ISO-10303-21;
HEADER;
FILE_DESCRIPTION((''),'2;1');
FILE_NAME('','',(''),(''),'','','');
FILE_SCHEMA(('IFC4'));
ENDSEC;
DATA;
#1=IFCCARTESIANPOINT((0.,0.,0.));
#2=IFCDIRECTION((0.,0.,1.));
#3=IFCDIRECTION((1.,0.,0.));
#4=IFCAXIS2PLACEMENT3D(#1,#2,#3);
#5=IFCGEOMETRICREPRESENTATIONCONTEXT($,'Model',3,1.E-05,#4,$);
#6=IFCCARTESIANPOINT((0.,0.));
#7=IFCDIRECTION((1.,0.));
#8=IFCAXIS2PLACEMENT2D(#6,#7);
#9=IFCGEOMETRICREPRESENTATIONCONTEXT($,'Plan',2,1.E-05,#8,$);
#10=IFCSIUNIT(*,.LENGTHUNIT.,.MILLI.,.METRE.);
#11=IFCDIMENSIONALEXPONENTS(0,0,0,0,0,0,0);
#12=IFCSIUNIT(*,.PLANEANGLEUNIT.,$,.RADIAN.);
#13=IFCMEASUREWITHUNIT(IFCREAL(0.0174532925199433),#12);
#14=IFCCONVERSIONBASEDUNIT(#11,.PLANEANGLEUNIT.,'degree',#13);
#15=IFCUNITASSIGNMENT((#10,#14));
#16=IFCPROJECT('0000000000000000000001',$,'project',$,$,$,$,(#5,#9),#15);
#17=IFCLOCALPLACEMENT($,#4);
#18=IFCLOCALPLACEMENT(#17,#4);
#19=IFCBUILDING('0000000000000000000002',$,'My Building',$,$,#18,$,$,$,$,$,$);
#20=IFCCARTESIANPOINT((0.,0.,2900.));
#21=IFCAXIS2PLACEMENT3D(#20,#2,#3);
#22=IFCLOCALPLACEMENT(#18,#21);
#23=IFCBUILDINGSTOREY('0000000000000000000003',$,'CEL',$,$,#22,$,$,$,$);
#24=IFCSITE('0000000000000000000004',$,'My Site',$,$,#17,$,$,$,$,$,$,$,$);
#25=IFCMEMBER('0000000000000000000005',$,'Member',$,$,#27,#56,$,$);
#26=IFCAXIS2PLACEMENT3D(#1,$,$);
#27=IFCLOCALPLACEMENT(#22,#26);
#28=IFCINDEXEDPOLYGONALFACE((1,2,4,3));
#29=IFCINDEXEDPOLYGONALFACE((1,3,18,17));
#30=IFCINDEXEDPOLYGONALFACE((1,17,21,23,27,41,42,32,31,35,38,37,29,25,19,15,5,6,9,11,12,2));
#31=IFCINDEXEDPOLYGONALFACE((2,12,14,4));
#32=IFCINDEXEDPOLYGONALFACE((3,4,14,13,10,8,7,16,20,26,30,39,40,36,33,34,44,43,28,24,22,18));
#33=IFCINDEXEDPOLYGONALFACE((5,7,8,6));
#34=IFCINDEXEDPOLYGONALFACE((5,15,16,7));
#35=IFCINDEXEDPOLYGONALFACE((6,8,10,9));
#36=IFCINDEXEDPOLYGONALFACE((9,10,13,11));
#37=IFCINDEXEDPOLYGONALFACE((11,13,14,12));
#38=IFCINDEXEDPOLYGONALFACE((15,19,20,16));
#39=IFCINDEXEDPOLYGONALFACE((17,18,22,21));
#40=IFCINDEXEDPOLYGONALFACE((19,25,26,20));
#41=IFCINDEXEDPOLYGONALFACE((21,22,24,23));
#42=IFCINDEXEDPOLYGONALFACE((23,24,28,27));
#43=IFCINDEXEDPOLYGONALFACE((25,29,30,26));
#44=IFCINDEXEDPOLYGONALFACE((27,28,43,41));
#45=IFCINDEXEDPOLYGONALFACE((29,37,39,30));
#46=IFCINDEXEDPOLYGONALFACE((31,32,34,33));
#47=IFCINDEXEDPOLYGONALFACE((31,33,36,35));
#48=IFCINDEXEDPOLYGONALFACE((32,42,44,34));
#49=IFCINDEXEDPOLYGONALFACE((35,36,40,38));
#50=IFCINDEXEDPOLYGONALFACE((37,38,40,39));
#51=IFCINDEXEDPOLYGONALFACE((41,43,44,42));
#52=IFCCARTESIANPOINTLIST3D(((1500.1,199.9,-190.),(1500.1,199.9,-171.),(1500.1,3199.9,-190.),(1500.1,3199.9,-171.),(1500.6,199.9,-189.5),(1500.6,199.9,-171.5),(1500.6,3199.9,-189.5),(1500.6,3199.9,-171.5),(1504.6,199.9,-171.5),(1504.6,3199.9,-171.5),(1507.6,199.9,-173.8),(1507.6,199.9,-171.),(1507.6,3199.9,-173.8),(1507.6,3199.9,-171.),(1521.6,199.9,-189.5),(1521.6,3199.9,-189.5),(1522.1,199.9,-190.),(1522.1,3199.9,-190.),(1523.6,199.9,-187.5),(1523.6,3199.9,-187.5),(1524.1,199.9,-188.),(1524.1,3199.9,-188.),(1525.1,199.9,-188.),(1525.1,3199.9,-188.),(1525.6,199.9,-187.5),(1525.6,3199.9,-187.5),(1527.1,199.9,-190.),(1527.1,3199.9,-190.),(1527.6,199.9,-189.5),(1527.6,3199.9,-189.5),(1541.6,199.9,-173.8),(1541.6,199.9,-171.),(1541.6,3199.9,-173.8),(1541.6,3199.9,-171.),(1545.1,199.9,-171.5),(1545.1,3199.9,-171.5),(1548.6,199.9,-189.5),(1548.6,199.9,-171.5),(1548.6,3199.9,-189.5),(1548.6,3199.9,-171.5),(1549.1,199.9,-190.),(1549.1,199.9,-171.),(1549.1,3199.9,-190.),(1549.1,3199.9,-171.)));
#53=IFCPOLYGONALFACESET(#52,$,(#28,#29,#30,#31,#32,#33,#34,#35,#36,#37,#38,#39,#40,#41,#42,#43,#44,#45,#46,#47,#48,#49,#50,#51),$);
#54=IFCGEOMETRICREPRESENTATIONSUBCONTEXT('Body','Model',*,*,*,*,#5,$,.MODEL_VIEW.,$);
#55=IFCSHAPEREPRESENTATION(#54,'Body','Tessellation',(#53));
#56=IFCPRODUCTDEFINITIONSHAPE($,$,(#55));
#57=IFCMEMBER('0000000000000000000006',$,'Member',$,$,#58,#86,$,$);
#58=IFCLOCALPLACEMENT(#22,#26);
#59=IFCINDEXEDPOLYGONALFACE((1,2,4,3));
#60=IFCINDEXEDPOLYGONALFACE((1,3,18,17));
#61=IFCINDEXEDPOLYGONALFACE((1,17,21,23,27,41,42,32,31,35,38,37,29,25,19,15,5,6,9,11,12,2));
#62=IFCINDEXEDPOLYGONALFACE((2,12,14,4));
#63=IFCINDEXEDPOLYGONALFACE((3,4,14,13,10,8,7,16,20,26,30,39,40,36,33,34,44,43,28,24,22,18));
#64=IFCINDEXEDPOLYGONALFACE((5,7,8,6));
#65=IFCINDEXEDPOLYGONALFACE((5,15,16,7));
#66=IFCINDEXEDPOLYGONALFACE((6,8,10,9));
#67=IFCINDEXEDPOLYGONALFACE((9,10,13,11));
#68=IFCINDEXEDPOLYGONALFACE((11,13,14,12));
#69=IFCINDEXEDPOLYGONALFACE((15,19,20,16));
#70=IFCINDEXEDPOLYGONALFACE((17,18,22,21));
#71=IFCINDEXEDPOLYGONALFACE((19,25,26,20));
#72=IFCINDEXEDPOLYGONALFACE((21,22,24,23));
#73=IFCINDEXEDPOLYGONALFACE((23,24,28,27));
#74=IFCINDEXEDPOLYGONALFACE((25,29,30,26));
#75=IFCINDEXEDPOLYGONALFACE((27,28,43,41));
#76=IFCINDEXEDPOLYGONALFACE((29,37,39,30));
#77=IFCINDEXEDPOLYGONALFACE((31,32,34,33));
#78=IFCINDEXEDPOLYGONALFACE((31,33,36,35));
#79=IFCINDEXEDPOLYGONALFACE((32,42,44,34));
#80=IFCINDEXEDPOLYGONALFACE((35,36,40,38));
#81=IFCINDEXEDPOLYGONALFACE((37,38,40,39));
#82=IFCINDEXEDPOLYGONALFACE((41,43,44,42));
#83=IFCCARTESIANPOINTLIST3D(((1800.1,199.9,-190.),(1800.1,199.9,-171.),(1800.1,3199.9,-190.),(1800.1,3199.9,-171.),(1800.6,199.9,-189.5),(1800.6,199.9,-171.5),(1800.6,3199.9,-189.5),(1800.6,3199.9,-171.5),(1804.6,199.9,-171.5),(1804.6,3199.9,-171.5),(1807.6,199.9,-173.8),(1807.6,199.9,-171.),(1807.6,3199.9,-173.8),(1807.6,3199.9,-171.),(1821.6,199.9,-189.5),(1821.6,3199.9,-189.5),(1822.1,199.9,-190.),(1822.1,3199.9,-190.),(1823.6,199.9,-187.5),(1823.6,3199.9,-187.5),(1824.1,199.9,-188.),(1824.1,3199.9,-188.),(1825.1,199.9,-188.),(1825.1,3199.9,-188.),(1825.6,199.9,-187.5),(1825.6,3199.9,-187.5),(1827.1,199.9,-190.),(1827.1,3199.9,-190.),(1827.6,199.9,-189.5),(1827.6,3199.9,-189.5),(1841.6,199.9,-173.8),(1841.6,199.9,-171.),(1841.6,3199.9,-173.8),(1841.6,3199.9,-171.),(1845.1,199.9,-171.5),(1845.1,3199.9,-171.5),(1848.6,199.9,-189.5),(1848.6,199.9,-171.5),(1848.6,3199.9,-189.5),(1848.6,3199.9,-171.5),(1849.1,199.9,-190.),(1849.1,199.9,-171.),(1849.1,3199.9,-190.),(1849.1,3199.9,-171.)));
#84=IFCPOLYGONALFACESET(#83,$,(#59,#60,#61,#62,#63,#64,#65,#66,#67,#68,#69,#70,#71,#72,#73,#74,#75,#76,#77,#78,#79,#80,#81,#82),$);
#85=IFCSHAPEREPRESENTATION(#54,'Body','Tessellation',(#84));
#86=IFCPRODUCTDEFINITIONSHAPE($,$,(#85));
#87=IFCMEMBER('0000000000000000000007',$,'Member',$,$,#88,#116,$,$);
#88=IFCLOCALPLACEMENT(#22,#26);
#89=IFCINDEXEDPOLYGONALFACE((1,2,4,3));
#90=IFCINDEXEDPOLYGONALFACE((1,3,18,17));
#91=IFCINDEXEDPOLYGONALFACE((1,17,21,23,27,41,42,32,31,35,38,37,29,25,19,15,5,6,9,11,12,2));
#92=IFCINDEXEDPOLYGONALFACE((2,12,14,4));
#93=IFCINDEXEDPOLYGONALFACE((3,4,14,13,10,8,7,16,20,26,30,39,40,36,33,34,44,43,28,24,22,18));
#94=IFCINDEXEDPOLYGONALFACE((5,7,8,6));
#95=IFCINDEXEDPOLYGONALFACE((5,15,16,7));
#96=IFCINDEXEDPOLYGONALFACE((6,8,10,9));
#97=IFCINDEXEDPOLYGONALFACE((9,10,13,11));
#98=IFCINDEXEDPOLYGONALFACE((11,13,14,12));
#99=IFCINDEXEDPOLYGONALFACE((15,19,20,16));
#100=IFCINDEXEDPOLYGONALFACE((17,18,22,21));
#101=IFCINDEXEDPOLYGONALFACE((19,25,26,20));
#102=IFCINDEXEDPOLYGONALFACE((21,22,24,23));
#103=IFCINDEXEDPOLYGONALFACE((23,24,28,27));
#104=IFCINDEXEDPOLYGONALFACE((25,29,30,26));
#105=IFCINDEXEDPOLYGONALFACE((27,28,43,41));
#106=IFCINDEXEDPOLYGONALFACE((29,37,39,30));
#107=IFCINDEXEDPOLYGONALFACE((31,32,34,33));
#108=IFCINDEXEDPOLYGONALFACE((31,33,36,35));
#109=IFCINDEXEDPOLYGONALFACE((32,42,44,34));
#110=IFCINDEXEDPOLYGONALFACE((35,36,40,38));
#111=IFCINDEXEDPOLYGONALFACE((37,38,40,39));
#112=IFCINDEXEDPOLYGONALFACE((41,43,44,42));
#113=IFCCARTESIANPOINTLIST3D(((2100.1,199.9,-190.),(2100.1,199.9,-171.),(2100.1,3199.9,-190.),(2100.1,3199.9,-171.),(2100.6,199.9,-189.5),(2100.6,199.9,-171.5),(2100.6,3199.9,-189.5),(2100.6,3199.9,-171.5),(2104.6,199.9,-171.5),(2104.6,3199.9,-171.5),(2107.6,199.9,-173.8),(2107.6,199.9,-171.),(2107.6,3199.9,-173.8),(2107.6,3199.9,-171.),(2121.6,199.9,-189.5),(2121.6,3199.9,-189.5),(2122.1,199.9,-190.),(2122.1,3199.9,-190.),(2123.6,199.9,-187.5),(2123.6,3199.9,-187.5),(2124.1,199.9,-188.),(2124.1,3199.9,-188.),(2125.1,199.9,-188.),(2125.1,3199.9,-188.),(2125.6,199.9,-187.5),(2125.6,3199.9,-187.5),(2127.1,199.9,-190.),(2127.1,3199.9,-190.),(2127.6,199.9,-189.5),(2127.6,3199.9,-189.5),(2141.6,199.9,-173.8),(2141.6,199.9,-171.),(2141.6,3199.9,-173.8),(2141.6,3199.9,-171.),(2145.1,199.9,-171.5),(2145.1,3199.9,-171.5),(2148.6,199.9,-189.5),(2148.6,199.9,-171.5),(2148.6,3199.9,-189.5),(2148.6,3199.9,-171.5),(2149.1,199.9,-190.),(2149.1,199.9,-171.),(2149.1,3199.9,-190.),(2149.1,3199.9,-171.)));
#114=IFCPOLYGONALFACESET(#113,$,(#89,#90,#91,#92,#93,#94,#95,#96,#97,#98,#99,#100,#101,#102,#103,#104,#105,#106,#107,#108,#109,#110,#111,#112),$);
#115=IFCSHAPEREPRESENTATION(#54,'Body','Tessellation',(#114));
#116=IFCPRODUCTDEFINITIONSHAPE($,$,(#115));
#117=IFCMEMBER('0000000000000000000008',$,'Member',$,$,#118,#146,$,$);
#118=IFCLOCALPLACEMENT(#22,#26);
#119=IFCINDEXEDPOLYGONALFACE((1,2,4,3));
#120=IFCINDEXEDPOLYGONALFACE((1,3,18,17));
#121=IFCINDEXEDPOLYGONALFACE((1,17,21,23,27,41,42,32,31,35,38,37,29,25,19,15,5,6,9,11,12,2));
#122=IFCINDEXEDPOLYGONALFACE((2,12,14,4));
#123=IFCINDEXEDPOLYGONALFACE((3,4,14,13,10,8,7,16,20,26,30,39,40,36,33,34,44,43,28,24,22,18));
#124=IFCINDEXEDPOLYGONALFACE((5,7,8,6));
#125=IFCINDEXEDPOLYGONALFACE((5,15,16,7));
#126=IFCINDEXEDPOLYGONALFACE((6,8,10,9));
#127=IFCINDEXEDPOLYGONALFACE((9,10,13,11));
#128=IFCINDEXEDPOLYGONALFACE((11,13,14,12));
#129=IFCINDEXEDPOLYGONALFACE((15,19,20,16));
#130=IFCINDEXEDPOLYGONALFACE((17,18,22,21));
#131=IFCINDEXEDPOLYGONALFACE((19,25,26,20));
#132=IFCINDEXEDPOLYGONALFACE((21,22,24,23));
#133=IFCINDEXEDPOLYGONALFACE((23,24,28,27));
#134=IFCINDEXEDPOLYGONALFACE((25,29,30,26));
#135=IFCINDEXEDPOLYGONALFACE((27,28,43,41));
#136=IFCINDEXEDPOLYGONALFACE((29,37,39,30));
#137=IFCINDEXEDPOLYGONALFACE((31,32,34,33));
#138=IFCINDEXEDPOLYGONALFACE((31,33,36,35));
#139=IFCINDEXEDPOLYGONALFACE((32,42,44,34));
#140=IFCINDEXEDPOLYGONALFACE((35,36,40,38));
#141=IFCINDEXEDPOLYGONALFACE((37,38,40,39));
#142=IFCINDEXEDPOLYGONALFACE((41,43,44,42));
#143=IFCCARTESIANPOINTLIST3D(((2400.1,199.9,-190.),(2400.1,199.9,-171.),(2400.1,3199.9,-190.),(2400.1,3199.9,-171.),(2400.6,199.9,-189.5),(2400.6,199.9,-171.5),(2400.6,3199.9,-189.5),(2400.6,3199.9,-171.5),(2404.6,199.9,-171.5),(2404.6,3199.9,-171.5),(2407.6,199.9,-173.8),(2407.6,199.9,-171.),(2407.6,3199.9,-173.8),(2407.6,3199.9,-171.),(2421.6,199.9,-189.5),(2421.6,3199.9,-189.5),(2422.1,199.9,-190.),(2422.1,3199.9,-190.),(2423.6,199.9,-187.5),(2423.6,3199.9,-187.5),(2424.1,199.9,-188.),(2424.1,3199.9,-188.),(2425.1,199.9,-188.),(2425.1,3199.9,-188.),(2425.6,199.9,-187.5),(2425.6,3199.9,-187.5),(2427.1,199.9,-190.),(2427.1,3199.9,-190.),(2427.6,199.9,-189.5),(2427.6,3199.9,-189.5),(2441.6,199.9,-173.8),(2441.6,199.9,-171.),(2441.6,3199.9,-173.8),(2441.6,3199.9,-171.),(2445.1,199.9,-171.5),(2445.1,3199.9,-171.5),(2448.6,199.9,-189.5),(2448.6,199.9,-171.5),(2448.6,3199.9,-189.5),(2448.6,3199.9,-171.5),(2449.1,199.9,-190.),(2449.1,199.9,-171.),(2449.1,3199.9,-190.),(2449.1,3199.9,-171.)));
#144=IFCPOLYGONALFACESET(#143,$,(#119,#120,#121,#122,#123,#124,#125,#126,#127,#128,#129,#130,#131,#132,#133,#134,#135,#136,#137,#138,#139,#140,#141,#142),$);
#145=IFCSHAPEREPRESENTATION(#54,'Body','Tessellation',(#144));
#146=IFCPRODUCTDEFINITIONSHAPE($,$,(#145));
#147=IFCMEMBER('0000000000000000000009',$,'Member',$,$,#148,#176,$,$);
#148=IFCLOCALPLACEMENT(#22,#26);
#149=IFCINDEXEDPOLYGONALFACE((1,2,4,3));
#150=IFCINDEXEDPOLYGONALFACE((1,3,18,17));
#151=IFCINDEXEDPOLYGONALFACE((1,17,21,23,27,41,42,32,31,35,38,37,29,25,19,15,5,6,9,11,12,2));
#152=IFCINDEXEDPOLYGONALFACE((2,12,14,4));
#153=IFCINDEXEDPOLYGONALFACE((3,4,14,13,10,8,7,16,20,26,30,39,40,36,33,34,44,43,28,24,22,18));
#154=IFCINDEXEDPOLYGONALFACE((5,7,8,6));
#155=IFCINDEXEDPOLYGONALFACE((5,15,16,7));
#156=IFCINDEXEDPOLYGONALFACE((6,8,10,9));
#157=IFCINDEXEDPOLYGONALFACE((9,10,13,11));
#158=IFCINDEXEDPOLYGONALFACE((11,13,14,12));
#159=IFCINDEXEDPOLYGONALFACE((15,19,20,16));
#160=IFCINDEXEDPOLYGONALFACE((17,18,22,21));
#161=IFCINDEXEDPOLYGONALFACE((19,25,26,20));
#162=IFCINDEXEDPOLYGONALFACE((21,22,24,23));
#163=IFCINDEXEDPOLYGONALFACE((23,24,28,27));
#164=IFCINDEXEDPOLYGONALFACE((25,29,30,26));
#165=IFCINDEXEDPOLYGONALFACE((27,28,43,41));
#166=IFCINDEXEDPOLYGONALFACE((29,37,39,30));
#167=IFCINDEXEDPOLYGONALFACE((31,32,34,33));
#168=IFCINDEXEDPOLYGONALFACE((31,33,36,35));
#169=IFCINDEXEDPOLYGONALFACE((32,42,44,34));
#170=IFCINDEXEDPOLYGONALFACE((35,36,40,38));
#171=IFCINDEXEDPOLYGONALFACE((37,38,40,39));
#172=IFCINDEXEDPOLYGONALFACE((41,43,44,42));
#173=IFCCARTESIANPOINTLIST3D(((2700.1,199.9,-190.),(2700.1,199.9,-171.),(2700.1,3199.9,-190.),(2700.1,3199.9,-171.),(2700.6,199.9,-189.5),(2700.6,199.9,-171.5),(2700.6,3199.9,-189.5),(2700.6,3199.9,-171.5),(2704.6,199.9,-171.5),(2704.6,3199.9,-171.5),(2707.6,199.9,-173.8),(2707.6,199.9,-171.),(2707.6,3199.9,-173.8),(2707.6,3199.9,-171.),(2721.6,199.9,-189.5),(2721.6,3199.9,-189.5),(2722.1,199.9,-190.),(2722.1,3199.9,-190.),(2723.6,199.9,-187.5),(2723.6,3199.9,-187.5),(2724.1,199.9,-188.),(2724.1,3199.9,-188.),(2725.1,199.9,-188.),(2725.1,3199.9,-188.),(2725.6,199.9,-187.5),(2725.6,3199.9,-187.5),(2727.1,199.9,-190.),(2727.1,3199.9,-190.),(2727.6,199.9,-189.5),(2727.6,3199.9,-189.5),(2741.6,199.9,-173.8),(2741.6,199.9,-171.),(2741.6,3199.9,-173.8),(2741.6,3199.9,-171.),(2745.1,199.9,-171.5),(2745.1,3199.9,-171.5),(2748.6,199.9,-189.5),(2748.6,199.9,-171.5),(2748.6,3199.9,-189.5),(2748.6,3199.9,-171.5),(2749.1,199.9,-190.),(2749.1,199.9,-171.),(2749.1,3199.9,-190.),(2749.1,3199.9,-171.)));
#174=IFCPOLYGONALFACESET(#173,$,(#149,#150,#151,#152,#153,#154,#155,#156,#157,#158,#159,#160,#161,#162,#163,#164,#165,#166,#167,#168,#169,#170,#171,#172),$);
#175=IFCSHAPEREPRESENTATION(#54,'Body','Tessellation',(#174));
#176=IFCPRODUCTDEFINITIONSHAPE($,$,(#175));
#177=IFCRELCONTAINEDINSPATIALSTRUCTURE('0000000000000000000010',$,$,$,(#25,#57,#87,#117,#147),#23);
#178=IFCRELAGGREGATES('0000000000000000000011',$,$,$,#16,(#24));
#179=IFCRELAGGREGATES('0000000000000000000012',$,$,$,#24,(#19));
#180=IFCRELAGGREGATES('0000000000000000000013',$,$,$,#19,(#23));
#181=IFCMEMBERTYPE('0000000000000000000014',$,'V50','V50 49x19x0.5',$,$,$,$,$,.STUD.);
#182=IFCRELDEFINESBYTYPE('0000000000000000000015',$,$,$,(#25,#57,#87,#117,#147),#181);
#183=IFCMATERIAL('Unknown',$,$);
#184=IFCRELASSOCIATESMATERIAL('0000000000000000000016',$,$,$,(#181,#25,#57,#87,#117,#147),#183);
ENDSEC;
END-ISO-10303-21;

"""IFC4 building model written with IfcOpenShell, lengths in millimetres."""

from ifc_helpers import new_model, entity, si_unit, converted_unit, frame, origin_with_axes, origin_2d_with_axis, place, context, subcontext, project, spatial, indexed_curve, outline, extrude, material, material_profile, profile_set, profile_usage, type_object, element, save


model = new_model("IFC4")

# Units and contexts
model_context = context("Model", 3, precision=1e-05, world=origin_with_axes())
plan_context = context("Plan", 2, precision=1e-05, world=origin_2d_with_axis())
body_context = subcontext(model_context, "Body", "Model", "MODEL_VIEW")
ifc_project = project(units=[si_unit("LENGTHUNIT", "METRE", prefix="MILLI"), converted_unit("PLANEANGLEUNIT", "degree", entity("IfcReal", 0.0174532925199433), si_unit("PLANEANGLEUNIT", "RADIAN"), dimensions=[0, 0, 0, 0, 0, 0, 0])], contexts=[model_context, plan_context])

# Site, building, storey
site_placement = place(None, origin_with_axes())
site = spatial("IfcSite", under=ifc_project, at=site_placement, Name="My Site")
building_placement = place(site_placement, origin_with_axes())
building = spatial("IfcBuilding", under=site, at=building_placement, Name="My Building")
storey_placement = place(building_placement, frame((0.0, 0.0, 2900.0), z_axis=(0.0, 0.0, 1.0), x_axis=(1.0, 0.0, 0.0)))
storey = spatial("IfcBuildingStorey", under=building, at=storey_placement, Name="CEL")

# Members
ifc_material = material(Name="Unknown")
ifc_material_profile = material_profile(ifc_material, outline(indexed_curve([(-49.0, 0.0), (-49.0, 19.0), (-41.5, 19.0), (-41.5, 16.2), (-45.0, 18.5), (-48.5, 18.5), (-48.5, 0.5), (-27.5, 0.5), (-25.5, 2.5), (-23.5, 2.5), (-21.5, 0.5), (-0.5, 0.5), (-0.5, 18.5), (-4.5, 18.5), (-7.5, 16.2), (-7.5, 19.0), (0.0, 19.0), (0.0, 0.0), (-22.0, 0.0), (-24.0, 2.0), (-25.0, 2.0), (-27.0, 0.0), (-49.0, 0.0)])))
ifc_profile_set = profile_set([ifc_material_profile])
member_type = type_object("IfcMemberType", Name="V50", Description="V50 49x19x0.5", PredefinedType="STUD", material=ifc_profile_set)
ifc_profile_usage_1 = profile_usage(ifc_profile_set, cardinal=5)
member_1_placement = place(storey_placement, frame((1500.1, 199.9, -190.0), z_axis=(0.0, 1.0, 0.0), x_axis=(-1.0, 0.0, 0.0)))
element("IfcMember", 1, at=member_1_placement, inside=storey, type_object=member_type, material=ifc_profile_usage_1, Name="Member", context=body_context, shape_type="SweptSolid", body=[
    extrude(outline(indexed_curve([(-49.0, 0.0), (-49.0, 19.0), (-41.5, 19.0), (-41.5, 16.2), (-45.0, 18.5), (-48.5, 18.5), (-48.5, 0.5), (-27.5, 0.5), (-25.5, 2.5), (-23.5, 2.5), (-21.5, 0.5), (-0.5, 0.5), (-0.5, 18.5), (-4.5, 18.5), (-7.5, 16.2), (-7.5, 19.0), (0.0, 19.0), (0.0, 0.0), (-22.0, 0.0), (-24.0, 2.0), (-25.0, 2.0), (-27.0, 0.0), (-49.0, 0.0)])), origin_with_axes(), (0.0, 0.0, 1.0), 3000.0),
])
ifc_profile_usage_2 = profile_usage(ifc_profile_set, cardinal=5)
member_2_placement = place(storey_placement, frame((1800.1, 199.9, -190.0), z_axis=(0.0, 1.0, 0.0), x_axis=(-1.0, 0.0, 0.0)))
element("IfcMember", 2, at=member_2_placement, inside=storey, type_object=member_type, material=ifc_profile_usage_2, Name="Member", context=body_context, shape_type="SweptSolid", body=[
    extrude(outline(indexed_curve([(-49.0, 0.0), (-49.0, 19.0), (-41.5, 19.0), (-41.5, 16.2), (-45.0, 18.5), (-48.5, 18.5), (-48.5, 0.5), (-27.5, 0.5), (-25.5, 2.5), (-23.5, 2.5), (-21.5, 0.5), (-0.5, 0.5), (-0.5, 18.5), (-4.5, 18.5), (-7.5, 16.2), (-7.5, 19.0), (0.0, 19.0), (0.0, 0.0), (-22.0, 0.0), (-24.0, 2.0), (-25.0, 2.0), (-27.0, 0.0), (-49.0, 0.0)])), origin_with_axes(), (0.0, 0.0, 1.0), 3000.0),
])
ifc_profile_usage_3 = profile_usage(ifc_profile_set, cardinal=5)
member_3_placement = place(storey_placement, frame((2100.1, 199.9, -190.0), z_axis=(0.0, 1.0, 0.0), x_axis=(-1.0, 0.0, 0.0)))
element("IfcMember", 3, at=member_3_placement, inside=storey, type_object=member_type, material=ifc_profile_usage_3, Name="Member", context=body_context, shape_type="SweptSolid", body=[
    extrude(outline(indexed_curve([(-49.0, 0.0), (-49.0, 19.0), (-41.5, 19.0), (-41.5, 16.2), (-45.0, 18.5), (-48.5, 18.5), (-48.5, 0.5), (-27.5, 0.5), (-25.5, 2.5), (-23.5, 2.5), (-21.5, 0.5), (-0.5, 0.5), (-0.5, 18.5), (-4.5, 18.5), (-7.5, 16.2), (-7.5, 19.0), (0.0, 19.0), (0.0, 0.0), (-22.0, 0.0), (-24.0, 2.0), (-25.0, 2.0), (-27.0, 0.0), (-49.0, 0.0)])), origin_with_axes(), (0.0, 0.0, 1.0), 3000.0),
])
ifc_profile_usage_4 = profile_usage(ifc_profile_set, cardinal=5)
member_4_placement = place(storey_placement, frame((2400.1, 199.9, -190.0), z_axis=(0.0, 1.0, 0.0), x_axis=(-1.0, 0.0, 0.0)))
element("IfcMember", 4, at=member_4_placement, inside=storey, type_object=member_type, material=ifc_profile_usage_4, Name="Member", context=body_context, shape_type="SweptSolid", body=[
    extrude(outline(indexed_curve([(-49.0, 0.0), (-49.0, 19.0), (-41.5, 19.0), (-41.5, 16.2), (-45.0, 18.5), (-48.5, 18.5), (-48.5, 0.5), (-27.5, 0.5), (-25.5, 2.5), (-23.5, 2.5), (-21.5, 0.5), (-0.5, 0.5), (-0.5, 18.5), (-4.5, 18.5), (-7.5, 16.2), (-7.5, 19.0), (0.0, 19.0), (0.0, 0.0), (-22.0, 0.0), (-24.0, 2.0), (-25.0, 2.0), (-27.0, 0.0), (-49.0, 0.0)])), origin_with_axes(), (0.0, 0.0, 1.0), 3000.0),
])
ifc_profile_usage_5 = profile_usage(ifc_profile_set, cardinal=5)
member_5_placement = place(storey_placement, frame((2700.1, 199.9, -190.0), z_axis=(0.0, 1.0, 0.0), x_axis=(-1.0, 0.0, 0.0)))
element("IfcMember", 5, at=member_5_placement, inside=storey, type_object=member_type, material=ifc_profile_usage_5, Name="Member", context=body_context, shape_type="SweptSolid", body=[
    extrude(outline(indexed_curve([(-49.0, 0.0), (-49.0, 19.0), (-41.5, 19.0), (-41.5, 16.2), (-45.0, 18.5), (-48.5, 18.5), (-48.5, 0.5), (-27.5, 0.5), (-25.5, 2.5), (-23.5, 2.5), (-21.5, 0.5), (-0.5, 0.5), (-0.5, 18.5), (-4.5, 18.5), (-7.5, 16.2), (-7.5, 19.0), (0.0, 19.0), (0.0, 0.0), (-22.0, 0.0), (-24.0, 2.0), (-25.0, 2.0), (-27.0, 0.0), (-49.0, 0.0)])), origin_with_axes(), (0.0, 0.0, 1.0), 3000.0),
])

save(model, "model.ifc")
